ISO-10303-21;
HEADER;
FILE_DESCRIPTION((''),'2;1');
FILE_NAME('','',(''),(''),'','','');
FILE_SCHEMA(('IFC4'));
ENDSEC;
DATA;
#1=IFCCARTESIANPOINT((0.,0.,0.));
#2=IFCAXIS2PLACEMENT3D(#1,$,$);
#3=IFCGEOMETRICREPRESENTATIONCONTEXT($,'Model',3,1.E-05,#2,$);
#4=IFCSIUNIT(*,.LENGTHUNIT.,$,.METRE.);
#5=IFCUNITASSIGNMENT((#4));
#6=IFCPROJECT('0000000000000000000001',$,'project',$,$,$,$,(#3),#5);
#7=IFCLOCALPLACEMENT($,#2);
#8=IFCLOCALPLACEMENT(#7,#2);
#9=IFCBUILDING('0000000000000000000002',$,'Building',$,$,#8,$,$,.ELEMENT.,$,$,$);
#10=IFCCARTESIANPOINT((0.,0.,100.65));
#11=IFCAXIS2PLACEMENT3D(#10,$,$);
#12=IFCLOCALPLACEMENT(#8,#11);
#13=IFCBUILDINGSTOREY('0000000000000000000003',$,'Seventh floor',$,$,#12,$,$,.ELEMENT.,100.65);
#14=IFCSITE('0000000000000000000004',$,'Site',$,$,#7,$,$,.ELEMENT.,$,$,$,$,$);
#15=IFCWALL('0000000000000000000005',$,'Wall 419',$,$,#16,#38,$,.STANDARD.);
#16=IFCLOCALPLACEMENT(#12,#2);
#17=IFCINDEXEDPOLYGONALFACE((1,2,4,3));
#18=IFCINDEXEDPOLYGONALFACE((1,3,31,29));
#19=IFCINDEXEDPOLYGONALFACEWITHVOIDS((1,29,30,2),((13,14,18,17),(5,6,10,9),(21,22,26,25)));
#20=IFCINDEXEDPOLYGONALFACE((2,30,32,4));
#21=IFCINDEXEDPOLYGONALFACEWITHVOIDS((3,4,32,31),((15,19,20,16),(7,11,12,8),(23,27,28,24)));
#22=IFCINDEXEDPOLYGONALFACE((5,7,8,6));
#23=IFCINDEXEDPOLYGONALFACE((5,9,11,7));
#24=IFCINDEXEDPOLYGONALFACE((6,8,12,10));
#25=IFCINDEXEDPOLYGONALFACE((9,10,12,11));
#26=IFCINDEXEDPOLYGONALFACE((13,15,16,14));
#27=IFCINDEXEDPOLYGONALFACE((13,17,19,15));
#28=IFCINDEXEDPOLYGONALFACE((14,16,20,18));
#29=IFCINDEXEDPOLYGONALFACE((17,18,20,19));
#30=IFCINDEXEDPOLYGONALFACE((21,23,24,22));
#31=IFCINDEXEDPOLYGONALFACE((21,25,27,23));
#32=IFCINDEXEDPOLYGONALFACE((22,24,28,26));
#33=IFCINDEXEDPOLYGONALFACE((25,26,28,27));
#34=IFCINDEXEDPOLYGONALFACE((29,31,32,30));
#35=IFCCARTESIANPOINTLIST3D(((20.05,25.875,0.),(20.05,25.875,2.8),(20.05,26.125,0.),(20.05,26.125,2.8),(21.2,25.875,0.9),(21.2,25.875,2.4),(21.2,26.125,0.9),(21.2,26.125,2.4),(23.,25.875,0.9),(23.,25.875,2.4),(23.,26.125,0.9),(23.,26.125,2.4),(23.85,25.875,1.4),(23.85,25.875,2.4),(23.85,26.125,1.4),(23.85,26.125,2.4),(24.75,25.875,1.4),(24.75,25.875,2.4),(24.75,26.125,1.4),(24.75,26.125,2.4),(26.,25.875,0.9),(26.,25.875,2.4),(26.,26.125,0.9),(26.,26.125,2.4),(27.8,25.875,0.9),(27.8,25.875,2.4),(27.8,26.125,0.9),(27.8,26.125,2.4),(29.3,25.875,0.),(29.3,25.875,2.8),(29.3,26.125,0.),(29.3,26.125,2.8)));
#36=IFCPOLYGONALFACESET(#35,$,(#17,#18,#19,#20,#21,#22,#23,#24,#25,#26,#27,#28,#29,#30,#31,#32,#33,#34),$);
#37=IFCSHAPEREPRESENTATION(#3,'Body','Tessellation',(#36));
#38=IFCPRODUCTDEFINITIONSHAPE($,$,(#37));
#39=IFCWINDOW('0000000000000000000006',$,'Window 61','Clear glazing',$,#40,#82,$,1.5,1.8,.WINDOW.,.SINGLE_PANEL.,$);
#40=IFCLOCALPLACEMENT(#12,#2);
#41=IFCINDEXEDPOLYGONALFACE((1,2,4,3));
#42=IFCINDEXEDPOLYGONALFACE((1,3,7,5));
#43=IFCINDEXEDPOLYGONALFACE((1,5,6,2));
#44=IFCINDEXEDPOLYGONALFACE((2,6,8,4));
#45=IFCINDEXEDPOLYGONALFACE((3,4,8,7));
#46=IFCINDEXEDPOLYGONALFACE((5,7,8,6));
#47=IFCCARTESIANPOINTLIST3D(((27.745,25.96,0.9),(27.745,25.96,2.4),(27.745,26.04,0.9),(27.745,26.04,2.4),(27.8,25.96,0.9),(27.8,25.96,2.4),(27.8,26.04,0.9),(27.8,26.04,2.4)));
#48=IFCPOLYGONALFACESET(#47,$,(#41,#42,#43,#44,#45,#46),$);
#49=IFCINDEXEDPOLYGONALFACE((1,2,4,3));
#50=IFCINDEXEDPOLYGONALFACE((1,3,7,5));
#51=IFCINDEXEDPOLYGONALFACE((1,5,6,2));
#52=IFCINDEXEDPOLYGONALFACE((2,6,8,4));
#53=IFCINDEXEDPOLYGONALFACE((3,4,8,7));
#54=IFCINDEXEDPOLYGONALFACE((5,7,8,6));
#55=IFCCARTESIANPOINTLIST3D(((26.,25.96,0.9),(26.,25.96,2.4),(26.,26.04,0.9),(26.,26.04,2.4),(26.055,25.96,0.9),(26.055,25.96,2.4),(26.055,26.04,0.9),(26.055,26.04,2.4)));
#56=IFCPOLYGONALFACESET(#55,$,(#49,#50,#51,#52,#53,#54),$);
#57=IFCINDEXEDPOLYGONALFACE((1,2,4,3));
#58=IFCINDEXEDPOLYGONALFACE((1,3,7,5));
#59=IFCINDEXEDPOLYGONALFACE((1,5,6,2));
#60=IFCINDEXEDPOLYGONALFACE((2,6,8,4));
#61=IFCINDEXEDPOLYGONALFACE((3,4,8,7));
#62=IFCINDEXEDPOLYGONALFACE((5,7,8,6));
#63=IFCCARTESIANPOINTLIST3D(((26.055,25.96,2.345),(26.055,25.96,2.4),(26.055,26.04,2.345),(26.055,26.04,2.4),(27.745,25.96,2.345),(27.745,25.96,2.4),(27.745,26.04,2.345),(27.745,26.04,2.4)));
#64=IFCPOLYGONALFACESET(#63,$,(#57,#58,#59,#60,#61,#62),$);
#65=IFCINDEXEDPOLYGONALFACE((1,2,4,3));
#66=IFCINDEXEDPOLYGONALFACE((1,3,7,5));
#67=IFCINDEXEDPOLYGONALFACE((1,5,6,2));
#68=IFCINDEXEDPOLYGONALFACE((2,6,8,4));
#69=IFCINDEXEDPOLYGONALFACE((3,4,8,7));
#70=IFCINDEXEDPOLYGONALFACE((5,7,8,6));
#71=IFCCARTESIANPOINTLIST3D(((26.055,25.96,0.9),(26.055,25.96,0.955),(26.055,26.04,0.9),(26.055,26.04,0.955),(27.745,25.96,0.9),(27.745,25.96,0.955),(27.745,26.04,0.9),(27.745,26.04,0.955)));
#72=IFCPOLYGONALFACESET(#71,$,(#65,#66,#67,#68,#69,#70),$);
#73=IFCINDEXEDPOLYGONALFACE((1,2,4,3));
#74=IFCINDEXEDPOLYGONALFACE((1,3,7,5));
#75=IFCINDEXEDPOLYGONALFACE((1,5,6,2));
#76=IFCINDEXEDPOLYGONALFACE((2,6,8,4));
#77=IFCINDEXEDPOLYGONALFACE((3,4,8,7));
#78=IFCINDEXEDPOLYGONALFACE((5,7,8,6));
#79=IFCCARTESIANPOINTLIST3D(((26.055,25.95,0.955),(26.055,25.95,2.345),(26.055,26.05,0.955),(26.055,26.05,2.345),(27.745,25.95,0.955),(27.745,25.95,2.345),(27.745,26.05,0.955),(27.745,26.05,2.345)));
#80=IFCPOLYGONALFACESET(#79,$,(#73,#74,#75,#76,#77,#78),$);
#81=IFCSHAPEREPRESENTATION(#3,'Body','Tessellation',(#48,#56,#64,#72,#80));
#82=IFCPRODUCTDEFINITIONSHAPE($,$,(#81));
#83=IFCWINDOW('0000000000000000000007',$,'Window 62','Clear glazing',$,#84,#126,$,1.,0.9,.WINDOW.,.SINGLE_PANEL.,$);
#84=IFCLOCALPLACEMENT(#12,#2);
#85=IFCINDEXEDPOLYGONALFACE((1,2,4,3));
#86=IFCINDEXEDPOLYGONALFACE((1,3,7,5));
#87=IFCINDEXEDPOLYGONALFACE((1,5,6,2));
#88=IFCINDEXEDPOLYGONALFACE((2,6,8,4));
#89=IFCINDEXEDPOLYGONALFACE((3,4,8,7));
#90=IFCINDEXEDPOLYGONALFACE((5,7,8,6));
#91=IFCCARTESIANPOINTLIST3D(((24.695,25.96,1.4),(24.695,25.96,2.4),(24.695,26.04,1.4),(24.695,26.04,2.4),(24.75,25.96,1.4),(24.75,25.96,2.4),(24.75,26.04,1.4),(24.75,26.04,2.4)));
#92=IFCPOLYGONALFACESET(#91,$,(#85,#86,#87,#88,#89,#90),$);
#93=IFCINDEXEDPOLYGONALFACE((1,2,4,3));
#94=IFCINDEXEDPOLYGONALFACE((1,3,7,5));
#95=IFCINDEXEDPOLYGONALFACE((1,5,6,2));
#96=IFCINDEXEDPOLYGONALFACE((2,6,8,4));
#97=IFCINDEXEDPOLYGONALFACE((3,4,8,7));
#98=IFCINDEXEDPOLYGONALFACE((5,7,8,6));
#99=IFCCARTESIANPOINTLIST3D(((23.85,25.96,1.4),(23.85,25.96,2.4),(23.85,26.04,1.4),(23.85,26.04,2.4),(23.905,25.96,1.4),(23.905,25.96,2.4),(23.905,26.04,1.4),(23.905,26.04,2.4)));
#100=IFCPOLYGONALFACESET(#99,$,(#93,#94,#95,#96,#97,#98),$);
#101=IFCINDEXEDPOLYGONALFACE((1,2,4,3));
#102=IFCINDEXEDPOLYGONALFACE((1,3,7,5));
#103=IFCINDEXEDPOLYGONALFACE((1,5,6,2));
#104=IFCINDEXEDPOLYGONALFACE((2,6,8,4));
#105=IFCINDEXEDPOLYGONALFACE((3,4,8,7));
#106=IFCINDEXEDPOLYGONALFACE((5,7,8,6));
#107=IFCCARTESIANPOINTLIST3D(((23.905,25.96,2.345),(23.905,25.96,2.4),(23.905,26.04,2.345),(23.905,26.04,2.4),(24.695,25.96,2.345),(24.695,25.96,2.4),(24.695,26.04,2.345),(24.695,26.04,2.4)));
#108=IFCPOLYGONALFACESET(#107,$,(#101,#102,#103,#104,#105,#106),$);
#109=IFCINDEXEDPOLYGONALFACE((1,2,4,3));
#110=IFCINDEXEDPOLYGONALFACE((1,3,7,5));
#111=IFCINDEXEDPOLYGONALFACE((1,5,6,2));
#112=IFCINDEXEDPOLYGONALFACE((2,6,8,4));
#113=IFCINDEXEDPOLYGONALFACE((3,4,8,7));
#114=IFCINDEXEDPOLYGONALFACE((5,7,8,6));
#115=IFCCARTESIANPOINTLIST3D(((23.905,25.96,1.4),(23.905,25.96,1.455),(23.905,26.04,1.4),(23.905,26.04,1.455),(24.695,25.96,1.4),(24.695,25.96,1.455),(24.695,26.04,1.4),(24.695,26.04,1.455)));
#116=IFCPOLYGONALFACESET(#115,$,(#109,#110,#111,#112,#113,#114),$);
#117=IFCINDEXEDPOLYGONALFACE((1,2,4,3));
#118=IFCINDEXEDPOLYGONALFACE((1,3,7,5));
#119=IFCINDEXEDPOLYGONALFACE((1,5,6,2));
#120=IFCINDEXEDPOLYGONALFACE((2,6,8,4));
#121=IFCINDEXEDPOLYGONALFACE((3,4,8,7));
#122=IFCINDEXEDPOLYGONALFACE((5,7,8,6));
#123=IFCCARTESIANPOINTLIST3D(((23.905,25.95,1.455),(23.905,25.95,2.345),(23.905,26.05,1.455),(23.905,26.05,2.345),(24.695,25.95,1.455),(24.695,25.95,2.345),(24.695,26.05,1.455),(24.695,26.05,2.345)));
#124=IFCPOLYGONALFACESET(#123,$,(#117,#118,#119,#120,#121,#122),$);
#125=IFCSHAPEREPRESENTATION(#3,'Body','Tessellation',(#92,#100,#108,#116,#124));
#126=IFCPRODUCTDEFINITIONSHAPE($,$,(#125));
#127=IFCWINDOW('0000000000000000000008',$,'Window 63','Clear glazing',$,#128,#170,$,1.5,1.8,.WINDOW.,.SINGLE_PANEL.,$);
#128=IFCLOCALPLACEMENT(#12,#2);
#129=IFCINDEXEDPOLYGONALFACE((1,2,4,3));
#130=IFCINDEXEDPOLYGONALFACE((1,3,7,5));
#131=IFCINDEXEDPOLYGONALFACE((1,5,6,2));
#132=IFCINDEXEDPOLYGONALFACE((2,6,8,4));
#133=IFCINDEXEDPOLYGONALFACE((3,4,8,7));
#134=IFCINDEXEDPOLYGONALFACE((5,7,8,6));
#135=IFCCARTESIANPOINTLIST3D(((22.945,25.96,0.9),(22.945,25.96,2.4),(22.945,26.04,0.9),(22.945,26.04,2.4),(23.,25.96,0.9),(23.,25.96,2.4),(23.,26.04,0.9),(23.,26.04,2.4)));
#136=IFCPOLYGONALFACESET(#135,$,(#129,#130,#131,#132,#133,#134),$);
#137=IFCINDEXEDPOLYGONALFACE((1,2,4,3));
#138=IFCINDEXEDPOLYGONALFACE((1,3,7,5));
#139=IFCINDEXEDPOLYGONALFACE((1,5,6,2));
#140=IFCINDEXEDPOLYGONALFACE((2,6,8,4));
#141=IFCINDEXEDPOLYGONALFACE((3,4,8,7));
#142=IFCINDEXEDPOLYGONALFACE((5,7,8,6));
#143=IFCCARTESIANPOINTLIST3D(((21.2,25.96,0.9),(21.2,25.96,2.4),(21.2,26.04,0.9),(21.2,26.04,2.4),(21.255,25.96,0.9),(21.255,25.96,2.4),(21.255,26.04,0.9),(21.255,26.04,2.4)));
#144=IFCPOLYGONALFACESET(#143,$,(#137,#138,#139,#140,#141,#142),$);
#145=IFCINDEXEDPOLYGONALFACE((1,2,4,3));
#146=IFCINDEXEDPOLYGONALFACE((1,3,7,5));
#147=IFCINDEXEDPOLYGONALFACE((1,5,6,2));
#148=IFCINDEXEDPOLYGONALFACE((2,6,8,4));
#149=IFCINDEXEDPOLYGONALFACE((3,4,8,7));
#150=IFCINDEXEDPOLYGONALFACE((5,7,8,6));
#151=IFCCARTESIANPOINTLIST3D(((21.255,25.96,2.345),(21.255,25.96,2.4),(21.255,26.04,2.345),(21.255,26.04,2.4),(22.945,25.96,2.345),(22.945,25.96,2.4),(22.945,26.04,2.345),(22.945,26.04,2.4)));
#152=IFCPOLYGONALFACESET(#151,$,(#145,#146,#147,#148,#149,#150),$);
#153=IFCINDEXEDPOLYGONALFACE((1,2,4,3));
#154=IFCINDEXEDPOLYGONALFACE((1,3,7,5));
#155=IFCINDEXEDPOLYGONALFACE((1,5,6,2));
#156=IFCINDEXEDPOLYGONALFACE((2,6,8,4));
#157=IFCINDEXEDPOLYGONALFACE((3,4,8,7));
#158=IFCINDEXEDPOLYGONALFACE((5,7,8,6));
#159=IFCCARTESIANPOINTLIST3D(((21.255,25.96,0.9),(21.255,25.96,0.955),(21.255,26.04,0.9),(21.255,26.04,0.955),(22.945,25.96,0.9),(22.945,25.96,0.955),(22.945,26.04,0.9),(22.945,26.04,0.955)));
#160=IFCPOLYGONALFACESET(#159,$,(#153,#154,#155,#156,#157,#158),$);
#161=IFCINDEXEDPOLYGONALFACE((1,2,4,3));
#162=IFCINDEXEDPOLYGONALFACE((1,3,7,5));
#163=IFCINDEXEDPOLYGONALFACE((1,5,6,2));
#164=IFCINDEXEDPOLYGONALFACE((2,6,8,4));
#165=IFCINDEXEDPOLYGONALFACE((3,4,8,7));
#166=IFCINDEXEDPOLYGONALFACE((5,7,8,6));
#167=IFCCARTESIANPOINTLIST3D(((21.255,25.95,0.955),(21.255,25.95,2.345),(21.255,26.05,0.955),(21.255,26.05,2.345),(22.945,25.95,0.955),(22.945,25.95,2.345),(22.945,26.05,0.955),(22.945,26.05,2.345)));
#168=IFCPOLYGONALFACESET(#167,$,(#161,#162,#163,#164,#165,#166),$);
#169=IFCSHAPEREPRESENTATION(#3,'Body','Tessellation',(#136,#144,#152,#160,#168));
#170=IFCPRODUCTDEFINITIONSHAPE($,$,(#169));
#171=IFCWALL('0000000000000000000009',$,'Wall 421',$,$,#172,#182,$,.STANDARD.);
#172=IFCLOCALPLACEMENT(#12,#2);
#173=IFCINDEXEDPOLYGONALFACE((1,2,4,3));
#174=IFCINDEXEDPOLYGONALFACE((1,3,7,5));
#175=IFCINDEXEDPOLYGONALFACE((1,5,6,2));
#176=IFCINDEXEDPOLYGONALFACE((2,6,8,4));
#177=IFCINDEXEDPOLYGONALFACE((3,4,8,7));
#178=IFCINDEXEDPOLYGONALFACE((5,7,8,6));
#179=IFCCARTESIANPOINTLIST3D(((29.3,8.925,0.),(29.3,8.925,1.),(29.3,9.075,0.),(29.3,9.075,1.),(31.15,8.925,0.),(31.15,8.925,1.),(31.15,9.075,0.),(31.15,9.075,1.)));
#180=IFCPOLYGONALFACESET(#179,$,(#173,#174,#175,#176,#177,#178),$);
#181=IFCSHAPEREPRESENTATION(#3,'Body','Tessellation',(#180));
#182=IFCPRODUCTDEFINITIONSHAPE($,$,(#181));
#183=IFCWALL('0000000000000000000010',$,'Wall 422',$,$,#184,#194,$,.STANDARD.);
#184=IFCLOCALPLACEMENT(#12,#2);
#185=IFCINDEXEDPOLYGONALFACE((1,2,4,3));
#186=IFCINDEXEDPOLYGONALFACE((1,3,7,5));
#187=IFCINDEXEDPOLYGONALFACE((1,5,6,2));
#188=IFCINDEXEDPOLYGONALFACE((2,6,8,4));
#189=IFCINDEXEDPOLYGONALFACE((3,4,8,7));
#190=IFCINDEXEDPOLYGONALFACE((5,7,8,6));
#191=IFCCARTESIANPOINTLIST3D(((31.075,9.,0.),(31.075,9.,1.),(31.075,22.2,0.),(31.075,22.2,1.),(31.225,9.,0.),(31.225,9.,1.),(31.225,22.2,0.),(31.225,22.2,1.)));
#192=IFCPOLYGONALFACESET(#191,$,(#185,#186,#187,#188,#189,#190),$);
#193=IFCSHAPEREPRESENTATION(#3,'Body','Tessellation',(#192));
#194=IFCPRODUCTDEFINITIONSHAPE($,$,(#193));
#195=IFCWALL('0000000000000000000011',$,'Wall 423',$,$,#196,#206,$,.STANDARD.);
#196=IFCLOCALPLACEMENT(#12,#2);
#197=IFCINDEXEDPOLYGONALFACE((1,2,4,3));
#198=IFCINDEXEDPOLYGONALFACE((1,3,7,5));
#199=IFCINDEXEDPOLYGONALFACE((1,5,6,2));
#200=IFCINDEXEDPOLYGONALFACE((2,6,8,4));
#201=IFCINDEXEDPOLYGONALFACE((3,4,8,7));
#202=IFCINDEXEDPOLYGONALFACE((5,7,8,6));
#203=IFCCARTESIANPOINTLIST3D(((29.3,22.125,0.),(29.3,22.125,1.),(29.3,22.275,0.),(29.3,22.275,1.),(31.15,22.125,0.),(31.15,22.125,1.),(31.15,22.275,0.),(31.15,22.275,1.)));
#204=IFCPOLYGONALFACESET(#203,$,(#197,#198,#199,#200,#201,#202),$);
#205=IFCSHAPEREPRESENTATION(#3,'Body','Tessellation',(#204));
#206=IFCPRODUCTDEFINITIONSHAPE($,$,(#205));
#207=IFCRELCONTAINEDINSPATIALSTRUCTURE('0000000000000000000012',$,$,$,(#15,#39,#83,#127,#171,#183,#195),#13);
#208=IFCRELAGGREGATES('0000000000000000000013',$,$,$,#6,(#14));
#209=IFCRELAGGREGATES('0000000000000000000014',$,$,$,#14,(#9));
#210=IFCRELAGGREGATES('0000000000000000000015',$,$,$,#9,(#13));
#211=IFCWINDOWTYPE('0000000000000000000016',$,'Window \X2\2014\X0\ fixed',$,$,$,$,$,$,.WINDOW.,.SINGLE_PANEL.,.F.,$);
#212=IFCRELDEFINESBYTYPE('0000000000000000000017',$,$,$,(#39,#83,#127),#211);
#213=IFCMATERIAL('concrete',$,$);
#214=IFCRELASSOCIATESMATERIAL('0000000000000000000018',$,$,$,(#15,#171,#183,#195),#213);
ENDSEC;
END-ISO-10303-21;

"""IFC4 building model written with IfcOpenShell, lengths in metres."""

from ifc_helpers import new_model, si_unit, frame, frame_2d, origin, place, context, project, spatial, rectangle, extrude, material, type_object, element, fill, save


model = new_model("IFC4")

# Units and contexts
model_context = context("Model", 3, precision=1e-05, world=origin())
ifc_project = project(units=[si_unit("LENGTHUNIT", "METRE")], contexts=[model_context])

# Site, building, storey
site_placement = place(None, origin())
site = spatial("IfcSite", under=ifc_project, at=site_placement, Name="Site", CompositionType="ELEMENT")
building_placement = place(site_placement, origin())
building = spatial("IfcBuilding", under=site, at=building_placement, Name="Building", CompositionType="ELEMENT")
storey_placement = place(building_placement, frame((0.0, 0.0, 100.65)))
storey = spatial("IfcBuildingStorey", under=building, at=storey_placement, Name="Seventh floor", CompositionType="ELEMENT", Elevation=100.65)

# Shared definitions
ifc_material = material(Name="concrete")

# Shared definitions
window_type = type_object("IfcWindowType", Name="Window — fixed", ParameterTakesPrecedence=False, PartitioningType="SINGLE_PANEL", PredefinedType="WINDOW")

# Wall, openings, windows
wall_1_placement = place(storey_placement, frame((29.3, 26.0, 0.0), z_axis=(0.0, 0.0, 1.0), x_axis=(-1.0, 0.0, 0.0)))
wall_1 = element("IfcWall", 1, at=wall_1_placement, inside=storey, material=ifc_material, Name="Wall 419", PredefinedType="STANDARD", context=model_context, shape_type="SweptSolid", body=[
    extrude(rectangle(XDim=9.25, YDim=0.25, at=frame_2d((4.625, 0.0))), origin(), (0.0, 0.0, 1.0), 2.8),
])
opening_1_placement = place(storey_placement, frame((27.8, 26.0, 0.9), z_axis=(0.0, 0.0, 1.0), x_axis=(-1.0, 0.0, 0.0)))
opening_1 = element("IfcOpeningElement", 2, at=opening_1_placement, cuts=wall_1, PredefinedType="OPENING", context=model_context, shape_type="SweptSolid", body=[
    extrude(rectangle(XDim=1.8, YDim=0.31, at=frame_2d((0.9, 0.0))), origin(), (0.0, 0.0, 1.0), 1.5),
])
opening_2_placement = place(storey_placement, frame((24.75, 26.0, 1.4), z_axis=(0.0, 0.0, 1.0), x_axis=(-1.0, 0.0, 0.0)))
opening_2 = element("IfcOpeningElement", 3, at=opening_2_placement, cuts=wall_1, PredefinedType="OPENING", context=model_context, shape_type="SweptSolid", body=[
    extrude(rectangle(XDim=0.9, YDim=0.31, at=frame_2d((0.45, 0.0))), origin(), (0.0, 0.0, 1.0), 1.0),
])
opening_3_placement = place(storey_placement, frame((23.0, 26.0, 0.9), z_axis=(0.0, 0.0, 1.0), x_axis=(-1.0, 0.0, 0.0)))
opening_3 = element("IfcOpeningElement", 4, at=opening_3_placement, cuts=wall_1, PredefinedType="OPENING", context=model_context, shape_type="SweptSolid", body=[
    extrude(rectangle(XDim=1.8, YDim=0.31, at=frame_2d((0.9, 0.0))), origin(), (0.0, 0.0, 1.0), 1.5),
])
window_1_placement = place(storey_placement, frame((27.8, 26.0, 0.9), z_axis=(0.0, 0.0, 1.0), x_axis=(-1.0, 0.0, 0.0)))
window_1 = element("IfcWindow", 5, at=window_1_placement, inside=storey, type_object=window_type, Name="Window 61", Description="Clear glazing", OverallHeight=1.5, OverallWidth=1.8, PartitioningType="SINGLE_PANEL", PredefinedType="WINDOW", context=model_context, shape_type="SweptSolid", body=[
    extrude(rectangle(XDim=0.055, YDim=0.08, at=frame_2d((0.0275, 0.0))), origin(), (0.0, 0.0, 1.0), 1.5),
    extrude(rectangle(XDim=0.055, YDim=0.08, at=frame_2d((1.7725, 0.0))), origin(), (0.0, 0.0, 1.0), 1.5),
    extrude(rectangle(XDim=1.69, YDim=0.08, at=frame_2d((0.9, 0.0))), frame((0.0, 0.0, 1.445)), (0.0, 0.0, 1.0), 0.055),
    extrude(rectangle(XDim=1.69, YDim=0.08, at=frame_2d((0.9, 0.0))), origin(), (0.0, 0.0, 1.0), 0.055),
    extrude(rectangle(XDim=1.69, YDim=0.1, at=frame_2d((0.9, 0.0))), frame((0.0, 0.0, 0.055)), (0.0, 0.0, 1.0), 1.39),
])
fill(opening_1, window_1)
window_2_placement = place(storey_placement, frame((24.75, 26.0, 1.4), z_axis=(0.0, 0.0, 1.0), x_axis=(-1.0, 0.0, 0.0)))
window_2 = element("IfcWindow", 6, at=window_2_placement, inside=storey, type_object=window_type, Name="Window 62", Description="Clear glazing", OverallHeight=1.0, OverallWidth=0.9, PartitioningType="SINGLE_PANEL", PredefinedType="WINDOW", context=model_context, shape_type="SweptSolid", body=[
    extrude(rectangle(XDim=0.055, YDim=0.08, at=frame_2d((0.0275, 0.0))), origin(), (0.0, 0.0, 1.0), 1.0),
    extrude(rectangle(XDim=0.055, YDim=0.08, at=frame_2d((0.8725, 0.0))), origin(), (0.0, 0.0, 1.0), 1.0),
    extrude(rectangle(XDim=0.79, YDim=0.08, at=frame_2d((0.45, 0.0))), frame((0.0, 0.0, 0.945)), (0.0, 0.0, 1.0), 0.055),
    extrude(rectangle(XDim=0.79, YDim=0.08, at=frame_2d((0.45, 0.0))), origin(), (0.0, 0.0, 1.0), 0.055),
    extrude(rectangle(XDim=0.79, YDim=0.1, at=frame_2d((0.45, 0.0))), frame((0.0, 0.0, 0.055)), (0.0, 0.0, 1.0), 0.89),
])
fill(opening_2, window_2)
window_3_placement = place(storey_placement, frame((23.0, 26.0, 0.9), z_axis=(0.0, 0.0, 1.0), x_axis=(-1.0, 0.0, 0.0)))
window_3 = element("IfcWindow", 7, at=window_3_placement, inside=storey, type_object=window_type, Name="Window 63", Description="Clear glazing", OverallHeight=1.5, OverallWidth=1.8, PartitioningType="SINGLE_PANEL", PredefinedType="WINDOW", context=model_context, shape_type="SweptSolid", body=[
    extrude(rectangle(XDim=0.055, YDim=0.08, at=frame_2d((0.0275, 0.0))), origin(), (0.0, 0.0, 1.0), 1.5),
    extrude(rectangle(XDim=0.055, YDim=0.08, at=frame_2d((1.7725, 0.0))), origin(), (0.0, 0.0, 1.0), 1.5),
    extrude(rectangle(XDim=1.69, YDim=0.08, at=frame_2d((0.9, 0.0))), frame((0.0, 0.0, 1.445)), (0.0, 0.0, 1.0), 0.055),
    extrude(rectangle(XDim=1.69, YDim=0.08, at=frame_2d((0.9, 0.0))), origin(), (0.0, 0.0, 1.0), 0.055),
    extrude(rectangle(XDim=1.69, YDim=0.1, at=frame_2d((0.9, 0.0))), frame((0.0, 0.0, 0.055)), (0.0, 0.0, 1.0), 1.39),
])
fill(opening_3, window_3)

# Walls
wall_2_placement = place(storey_placement, frame((29.3, 9.0, 0.0), z_axis=(0.0, 0.0, 1.0), x_axis=(1.0, 0.0, 0.0)))
element("IfcWall", 8, at=wall_2_placement, inside=storey, material=ifc_material, Name="Wall 421", PredefinedType="STANDARD", context=model_context, shape_type="SweptSolid", body=[
    extrude(rectangle(XDim=1.85, YDim=0.15, at=frame_2d((0.925, 0.0))), origin(), (0.0, 0.0, 1.0), 1.0),
])
wall_3_placement = place(storey_placement, frame((31.15, 9.0, 0.0), z_axis=(0.0, 0.0, 1.0), x_axis=(0.0, 1.0, 0.0)))
element("IfcWall", 9, at=wall_3_placement, inside=storey, material=ifc_material, Name="Wall 422", PredefinedType="STANDARD", context=model_context, shape_type="SweptSolid", body=[
    extrude(rectangle(XDim=13.2, YDim=0.15, at=frame_2d((6.6, 0.0))), origin(), (0.0, 0.0, 1.0), 1.0),
])
wall_4_placement = place(storey_placement, frame((31.15, 22.2, 0.0), z_axis=(0.0, 0.0, 1.0), x_axis=(-1.0, 0.0, 0.0)))
element("IfcWall", 10, at=wall_4_placement, inside=storey, material=ifc_material, Name="Wall 423", PredefinedType="STANDARD", context=model_context, shape_type="SweptSolid", body=[
    extrude(rectangle(XDim=1.85, YDim=0.15, at=frame_2d((0.925, 0.0))), origin(), (0.0, 0.0, 1.0), 1.0),
])

save(model, "model.ifc")
